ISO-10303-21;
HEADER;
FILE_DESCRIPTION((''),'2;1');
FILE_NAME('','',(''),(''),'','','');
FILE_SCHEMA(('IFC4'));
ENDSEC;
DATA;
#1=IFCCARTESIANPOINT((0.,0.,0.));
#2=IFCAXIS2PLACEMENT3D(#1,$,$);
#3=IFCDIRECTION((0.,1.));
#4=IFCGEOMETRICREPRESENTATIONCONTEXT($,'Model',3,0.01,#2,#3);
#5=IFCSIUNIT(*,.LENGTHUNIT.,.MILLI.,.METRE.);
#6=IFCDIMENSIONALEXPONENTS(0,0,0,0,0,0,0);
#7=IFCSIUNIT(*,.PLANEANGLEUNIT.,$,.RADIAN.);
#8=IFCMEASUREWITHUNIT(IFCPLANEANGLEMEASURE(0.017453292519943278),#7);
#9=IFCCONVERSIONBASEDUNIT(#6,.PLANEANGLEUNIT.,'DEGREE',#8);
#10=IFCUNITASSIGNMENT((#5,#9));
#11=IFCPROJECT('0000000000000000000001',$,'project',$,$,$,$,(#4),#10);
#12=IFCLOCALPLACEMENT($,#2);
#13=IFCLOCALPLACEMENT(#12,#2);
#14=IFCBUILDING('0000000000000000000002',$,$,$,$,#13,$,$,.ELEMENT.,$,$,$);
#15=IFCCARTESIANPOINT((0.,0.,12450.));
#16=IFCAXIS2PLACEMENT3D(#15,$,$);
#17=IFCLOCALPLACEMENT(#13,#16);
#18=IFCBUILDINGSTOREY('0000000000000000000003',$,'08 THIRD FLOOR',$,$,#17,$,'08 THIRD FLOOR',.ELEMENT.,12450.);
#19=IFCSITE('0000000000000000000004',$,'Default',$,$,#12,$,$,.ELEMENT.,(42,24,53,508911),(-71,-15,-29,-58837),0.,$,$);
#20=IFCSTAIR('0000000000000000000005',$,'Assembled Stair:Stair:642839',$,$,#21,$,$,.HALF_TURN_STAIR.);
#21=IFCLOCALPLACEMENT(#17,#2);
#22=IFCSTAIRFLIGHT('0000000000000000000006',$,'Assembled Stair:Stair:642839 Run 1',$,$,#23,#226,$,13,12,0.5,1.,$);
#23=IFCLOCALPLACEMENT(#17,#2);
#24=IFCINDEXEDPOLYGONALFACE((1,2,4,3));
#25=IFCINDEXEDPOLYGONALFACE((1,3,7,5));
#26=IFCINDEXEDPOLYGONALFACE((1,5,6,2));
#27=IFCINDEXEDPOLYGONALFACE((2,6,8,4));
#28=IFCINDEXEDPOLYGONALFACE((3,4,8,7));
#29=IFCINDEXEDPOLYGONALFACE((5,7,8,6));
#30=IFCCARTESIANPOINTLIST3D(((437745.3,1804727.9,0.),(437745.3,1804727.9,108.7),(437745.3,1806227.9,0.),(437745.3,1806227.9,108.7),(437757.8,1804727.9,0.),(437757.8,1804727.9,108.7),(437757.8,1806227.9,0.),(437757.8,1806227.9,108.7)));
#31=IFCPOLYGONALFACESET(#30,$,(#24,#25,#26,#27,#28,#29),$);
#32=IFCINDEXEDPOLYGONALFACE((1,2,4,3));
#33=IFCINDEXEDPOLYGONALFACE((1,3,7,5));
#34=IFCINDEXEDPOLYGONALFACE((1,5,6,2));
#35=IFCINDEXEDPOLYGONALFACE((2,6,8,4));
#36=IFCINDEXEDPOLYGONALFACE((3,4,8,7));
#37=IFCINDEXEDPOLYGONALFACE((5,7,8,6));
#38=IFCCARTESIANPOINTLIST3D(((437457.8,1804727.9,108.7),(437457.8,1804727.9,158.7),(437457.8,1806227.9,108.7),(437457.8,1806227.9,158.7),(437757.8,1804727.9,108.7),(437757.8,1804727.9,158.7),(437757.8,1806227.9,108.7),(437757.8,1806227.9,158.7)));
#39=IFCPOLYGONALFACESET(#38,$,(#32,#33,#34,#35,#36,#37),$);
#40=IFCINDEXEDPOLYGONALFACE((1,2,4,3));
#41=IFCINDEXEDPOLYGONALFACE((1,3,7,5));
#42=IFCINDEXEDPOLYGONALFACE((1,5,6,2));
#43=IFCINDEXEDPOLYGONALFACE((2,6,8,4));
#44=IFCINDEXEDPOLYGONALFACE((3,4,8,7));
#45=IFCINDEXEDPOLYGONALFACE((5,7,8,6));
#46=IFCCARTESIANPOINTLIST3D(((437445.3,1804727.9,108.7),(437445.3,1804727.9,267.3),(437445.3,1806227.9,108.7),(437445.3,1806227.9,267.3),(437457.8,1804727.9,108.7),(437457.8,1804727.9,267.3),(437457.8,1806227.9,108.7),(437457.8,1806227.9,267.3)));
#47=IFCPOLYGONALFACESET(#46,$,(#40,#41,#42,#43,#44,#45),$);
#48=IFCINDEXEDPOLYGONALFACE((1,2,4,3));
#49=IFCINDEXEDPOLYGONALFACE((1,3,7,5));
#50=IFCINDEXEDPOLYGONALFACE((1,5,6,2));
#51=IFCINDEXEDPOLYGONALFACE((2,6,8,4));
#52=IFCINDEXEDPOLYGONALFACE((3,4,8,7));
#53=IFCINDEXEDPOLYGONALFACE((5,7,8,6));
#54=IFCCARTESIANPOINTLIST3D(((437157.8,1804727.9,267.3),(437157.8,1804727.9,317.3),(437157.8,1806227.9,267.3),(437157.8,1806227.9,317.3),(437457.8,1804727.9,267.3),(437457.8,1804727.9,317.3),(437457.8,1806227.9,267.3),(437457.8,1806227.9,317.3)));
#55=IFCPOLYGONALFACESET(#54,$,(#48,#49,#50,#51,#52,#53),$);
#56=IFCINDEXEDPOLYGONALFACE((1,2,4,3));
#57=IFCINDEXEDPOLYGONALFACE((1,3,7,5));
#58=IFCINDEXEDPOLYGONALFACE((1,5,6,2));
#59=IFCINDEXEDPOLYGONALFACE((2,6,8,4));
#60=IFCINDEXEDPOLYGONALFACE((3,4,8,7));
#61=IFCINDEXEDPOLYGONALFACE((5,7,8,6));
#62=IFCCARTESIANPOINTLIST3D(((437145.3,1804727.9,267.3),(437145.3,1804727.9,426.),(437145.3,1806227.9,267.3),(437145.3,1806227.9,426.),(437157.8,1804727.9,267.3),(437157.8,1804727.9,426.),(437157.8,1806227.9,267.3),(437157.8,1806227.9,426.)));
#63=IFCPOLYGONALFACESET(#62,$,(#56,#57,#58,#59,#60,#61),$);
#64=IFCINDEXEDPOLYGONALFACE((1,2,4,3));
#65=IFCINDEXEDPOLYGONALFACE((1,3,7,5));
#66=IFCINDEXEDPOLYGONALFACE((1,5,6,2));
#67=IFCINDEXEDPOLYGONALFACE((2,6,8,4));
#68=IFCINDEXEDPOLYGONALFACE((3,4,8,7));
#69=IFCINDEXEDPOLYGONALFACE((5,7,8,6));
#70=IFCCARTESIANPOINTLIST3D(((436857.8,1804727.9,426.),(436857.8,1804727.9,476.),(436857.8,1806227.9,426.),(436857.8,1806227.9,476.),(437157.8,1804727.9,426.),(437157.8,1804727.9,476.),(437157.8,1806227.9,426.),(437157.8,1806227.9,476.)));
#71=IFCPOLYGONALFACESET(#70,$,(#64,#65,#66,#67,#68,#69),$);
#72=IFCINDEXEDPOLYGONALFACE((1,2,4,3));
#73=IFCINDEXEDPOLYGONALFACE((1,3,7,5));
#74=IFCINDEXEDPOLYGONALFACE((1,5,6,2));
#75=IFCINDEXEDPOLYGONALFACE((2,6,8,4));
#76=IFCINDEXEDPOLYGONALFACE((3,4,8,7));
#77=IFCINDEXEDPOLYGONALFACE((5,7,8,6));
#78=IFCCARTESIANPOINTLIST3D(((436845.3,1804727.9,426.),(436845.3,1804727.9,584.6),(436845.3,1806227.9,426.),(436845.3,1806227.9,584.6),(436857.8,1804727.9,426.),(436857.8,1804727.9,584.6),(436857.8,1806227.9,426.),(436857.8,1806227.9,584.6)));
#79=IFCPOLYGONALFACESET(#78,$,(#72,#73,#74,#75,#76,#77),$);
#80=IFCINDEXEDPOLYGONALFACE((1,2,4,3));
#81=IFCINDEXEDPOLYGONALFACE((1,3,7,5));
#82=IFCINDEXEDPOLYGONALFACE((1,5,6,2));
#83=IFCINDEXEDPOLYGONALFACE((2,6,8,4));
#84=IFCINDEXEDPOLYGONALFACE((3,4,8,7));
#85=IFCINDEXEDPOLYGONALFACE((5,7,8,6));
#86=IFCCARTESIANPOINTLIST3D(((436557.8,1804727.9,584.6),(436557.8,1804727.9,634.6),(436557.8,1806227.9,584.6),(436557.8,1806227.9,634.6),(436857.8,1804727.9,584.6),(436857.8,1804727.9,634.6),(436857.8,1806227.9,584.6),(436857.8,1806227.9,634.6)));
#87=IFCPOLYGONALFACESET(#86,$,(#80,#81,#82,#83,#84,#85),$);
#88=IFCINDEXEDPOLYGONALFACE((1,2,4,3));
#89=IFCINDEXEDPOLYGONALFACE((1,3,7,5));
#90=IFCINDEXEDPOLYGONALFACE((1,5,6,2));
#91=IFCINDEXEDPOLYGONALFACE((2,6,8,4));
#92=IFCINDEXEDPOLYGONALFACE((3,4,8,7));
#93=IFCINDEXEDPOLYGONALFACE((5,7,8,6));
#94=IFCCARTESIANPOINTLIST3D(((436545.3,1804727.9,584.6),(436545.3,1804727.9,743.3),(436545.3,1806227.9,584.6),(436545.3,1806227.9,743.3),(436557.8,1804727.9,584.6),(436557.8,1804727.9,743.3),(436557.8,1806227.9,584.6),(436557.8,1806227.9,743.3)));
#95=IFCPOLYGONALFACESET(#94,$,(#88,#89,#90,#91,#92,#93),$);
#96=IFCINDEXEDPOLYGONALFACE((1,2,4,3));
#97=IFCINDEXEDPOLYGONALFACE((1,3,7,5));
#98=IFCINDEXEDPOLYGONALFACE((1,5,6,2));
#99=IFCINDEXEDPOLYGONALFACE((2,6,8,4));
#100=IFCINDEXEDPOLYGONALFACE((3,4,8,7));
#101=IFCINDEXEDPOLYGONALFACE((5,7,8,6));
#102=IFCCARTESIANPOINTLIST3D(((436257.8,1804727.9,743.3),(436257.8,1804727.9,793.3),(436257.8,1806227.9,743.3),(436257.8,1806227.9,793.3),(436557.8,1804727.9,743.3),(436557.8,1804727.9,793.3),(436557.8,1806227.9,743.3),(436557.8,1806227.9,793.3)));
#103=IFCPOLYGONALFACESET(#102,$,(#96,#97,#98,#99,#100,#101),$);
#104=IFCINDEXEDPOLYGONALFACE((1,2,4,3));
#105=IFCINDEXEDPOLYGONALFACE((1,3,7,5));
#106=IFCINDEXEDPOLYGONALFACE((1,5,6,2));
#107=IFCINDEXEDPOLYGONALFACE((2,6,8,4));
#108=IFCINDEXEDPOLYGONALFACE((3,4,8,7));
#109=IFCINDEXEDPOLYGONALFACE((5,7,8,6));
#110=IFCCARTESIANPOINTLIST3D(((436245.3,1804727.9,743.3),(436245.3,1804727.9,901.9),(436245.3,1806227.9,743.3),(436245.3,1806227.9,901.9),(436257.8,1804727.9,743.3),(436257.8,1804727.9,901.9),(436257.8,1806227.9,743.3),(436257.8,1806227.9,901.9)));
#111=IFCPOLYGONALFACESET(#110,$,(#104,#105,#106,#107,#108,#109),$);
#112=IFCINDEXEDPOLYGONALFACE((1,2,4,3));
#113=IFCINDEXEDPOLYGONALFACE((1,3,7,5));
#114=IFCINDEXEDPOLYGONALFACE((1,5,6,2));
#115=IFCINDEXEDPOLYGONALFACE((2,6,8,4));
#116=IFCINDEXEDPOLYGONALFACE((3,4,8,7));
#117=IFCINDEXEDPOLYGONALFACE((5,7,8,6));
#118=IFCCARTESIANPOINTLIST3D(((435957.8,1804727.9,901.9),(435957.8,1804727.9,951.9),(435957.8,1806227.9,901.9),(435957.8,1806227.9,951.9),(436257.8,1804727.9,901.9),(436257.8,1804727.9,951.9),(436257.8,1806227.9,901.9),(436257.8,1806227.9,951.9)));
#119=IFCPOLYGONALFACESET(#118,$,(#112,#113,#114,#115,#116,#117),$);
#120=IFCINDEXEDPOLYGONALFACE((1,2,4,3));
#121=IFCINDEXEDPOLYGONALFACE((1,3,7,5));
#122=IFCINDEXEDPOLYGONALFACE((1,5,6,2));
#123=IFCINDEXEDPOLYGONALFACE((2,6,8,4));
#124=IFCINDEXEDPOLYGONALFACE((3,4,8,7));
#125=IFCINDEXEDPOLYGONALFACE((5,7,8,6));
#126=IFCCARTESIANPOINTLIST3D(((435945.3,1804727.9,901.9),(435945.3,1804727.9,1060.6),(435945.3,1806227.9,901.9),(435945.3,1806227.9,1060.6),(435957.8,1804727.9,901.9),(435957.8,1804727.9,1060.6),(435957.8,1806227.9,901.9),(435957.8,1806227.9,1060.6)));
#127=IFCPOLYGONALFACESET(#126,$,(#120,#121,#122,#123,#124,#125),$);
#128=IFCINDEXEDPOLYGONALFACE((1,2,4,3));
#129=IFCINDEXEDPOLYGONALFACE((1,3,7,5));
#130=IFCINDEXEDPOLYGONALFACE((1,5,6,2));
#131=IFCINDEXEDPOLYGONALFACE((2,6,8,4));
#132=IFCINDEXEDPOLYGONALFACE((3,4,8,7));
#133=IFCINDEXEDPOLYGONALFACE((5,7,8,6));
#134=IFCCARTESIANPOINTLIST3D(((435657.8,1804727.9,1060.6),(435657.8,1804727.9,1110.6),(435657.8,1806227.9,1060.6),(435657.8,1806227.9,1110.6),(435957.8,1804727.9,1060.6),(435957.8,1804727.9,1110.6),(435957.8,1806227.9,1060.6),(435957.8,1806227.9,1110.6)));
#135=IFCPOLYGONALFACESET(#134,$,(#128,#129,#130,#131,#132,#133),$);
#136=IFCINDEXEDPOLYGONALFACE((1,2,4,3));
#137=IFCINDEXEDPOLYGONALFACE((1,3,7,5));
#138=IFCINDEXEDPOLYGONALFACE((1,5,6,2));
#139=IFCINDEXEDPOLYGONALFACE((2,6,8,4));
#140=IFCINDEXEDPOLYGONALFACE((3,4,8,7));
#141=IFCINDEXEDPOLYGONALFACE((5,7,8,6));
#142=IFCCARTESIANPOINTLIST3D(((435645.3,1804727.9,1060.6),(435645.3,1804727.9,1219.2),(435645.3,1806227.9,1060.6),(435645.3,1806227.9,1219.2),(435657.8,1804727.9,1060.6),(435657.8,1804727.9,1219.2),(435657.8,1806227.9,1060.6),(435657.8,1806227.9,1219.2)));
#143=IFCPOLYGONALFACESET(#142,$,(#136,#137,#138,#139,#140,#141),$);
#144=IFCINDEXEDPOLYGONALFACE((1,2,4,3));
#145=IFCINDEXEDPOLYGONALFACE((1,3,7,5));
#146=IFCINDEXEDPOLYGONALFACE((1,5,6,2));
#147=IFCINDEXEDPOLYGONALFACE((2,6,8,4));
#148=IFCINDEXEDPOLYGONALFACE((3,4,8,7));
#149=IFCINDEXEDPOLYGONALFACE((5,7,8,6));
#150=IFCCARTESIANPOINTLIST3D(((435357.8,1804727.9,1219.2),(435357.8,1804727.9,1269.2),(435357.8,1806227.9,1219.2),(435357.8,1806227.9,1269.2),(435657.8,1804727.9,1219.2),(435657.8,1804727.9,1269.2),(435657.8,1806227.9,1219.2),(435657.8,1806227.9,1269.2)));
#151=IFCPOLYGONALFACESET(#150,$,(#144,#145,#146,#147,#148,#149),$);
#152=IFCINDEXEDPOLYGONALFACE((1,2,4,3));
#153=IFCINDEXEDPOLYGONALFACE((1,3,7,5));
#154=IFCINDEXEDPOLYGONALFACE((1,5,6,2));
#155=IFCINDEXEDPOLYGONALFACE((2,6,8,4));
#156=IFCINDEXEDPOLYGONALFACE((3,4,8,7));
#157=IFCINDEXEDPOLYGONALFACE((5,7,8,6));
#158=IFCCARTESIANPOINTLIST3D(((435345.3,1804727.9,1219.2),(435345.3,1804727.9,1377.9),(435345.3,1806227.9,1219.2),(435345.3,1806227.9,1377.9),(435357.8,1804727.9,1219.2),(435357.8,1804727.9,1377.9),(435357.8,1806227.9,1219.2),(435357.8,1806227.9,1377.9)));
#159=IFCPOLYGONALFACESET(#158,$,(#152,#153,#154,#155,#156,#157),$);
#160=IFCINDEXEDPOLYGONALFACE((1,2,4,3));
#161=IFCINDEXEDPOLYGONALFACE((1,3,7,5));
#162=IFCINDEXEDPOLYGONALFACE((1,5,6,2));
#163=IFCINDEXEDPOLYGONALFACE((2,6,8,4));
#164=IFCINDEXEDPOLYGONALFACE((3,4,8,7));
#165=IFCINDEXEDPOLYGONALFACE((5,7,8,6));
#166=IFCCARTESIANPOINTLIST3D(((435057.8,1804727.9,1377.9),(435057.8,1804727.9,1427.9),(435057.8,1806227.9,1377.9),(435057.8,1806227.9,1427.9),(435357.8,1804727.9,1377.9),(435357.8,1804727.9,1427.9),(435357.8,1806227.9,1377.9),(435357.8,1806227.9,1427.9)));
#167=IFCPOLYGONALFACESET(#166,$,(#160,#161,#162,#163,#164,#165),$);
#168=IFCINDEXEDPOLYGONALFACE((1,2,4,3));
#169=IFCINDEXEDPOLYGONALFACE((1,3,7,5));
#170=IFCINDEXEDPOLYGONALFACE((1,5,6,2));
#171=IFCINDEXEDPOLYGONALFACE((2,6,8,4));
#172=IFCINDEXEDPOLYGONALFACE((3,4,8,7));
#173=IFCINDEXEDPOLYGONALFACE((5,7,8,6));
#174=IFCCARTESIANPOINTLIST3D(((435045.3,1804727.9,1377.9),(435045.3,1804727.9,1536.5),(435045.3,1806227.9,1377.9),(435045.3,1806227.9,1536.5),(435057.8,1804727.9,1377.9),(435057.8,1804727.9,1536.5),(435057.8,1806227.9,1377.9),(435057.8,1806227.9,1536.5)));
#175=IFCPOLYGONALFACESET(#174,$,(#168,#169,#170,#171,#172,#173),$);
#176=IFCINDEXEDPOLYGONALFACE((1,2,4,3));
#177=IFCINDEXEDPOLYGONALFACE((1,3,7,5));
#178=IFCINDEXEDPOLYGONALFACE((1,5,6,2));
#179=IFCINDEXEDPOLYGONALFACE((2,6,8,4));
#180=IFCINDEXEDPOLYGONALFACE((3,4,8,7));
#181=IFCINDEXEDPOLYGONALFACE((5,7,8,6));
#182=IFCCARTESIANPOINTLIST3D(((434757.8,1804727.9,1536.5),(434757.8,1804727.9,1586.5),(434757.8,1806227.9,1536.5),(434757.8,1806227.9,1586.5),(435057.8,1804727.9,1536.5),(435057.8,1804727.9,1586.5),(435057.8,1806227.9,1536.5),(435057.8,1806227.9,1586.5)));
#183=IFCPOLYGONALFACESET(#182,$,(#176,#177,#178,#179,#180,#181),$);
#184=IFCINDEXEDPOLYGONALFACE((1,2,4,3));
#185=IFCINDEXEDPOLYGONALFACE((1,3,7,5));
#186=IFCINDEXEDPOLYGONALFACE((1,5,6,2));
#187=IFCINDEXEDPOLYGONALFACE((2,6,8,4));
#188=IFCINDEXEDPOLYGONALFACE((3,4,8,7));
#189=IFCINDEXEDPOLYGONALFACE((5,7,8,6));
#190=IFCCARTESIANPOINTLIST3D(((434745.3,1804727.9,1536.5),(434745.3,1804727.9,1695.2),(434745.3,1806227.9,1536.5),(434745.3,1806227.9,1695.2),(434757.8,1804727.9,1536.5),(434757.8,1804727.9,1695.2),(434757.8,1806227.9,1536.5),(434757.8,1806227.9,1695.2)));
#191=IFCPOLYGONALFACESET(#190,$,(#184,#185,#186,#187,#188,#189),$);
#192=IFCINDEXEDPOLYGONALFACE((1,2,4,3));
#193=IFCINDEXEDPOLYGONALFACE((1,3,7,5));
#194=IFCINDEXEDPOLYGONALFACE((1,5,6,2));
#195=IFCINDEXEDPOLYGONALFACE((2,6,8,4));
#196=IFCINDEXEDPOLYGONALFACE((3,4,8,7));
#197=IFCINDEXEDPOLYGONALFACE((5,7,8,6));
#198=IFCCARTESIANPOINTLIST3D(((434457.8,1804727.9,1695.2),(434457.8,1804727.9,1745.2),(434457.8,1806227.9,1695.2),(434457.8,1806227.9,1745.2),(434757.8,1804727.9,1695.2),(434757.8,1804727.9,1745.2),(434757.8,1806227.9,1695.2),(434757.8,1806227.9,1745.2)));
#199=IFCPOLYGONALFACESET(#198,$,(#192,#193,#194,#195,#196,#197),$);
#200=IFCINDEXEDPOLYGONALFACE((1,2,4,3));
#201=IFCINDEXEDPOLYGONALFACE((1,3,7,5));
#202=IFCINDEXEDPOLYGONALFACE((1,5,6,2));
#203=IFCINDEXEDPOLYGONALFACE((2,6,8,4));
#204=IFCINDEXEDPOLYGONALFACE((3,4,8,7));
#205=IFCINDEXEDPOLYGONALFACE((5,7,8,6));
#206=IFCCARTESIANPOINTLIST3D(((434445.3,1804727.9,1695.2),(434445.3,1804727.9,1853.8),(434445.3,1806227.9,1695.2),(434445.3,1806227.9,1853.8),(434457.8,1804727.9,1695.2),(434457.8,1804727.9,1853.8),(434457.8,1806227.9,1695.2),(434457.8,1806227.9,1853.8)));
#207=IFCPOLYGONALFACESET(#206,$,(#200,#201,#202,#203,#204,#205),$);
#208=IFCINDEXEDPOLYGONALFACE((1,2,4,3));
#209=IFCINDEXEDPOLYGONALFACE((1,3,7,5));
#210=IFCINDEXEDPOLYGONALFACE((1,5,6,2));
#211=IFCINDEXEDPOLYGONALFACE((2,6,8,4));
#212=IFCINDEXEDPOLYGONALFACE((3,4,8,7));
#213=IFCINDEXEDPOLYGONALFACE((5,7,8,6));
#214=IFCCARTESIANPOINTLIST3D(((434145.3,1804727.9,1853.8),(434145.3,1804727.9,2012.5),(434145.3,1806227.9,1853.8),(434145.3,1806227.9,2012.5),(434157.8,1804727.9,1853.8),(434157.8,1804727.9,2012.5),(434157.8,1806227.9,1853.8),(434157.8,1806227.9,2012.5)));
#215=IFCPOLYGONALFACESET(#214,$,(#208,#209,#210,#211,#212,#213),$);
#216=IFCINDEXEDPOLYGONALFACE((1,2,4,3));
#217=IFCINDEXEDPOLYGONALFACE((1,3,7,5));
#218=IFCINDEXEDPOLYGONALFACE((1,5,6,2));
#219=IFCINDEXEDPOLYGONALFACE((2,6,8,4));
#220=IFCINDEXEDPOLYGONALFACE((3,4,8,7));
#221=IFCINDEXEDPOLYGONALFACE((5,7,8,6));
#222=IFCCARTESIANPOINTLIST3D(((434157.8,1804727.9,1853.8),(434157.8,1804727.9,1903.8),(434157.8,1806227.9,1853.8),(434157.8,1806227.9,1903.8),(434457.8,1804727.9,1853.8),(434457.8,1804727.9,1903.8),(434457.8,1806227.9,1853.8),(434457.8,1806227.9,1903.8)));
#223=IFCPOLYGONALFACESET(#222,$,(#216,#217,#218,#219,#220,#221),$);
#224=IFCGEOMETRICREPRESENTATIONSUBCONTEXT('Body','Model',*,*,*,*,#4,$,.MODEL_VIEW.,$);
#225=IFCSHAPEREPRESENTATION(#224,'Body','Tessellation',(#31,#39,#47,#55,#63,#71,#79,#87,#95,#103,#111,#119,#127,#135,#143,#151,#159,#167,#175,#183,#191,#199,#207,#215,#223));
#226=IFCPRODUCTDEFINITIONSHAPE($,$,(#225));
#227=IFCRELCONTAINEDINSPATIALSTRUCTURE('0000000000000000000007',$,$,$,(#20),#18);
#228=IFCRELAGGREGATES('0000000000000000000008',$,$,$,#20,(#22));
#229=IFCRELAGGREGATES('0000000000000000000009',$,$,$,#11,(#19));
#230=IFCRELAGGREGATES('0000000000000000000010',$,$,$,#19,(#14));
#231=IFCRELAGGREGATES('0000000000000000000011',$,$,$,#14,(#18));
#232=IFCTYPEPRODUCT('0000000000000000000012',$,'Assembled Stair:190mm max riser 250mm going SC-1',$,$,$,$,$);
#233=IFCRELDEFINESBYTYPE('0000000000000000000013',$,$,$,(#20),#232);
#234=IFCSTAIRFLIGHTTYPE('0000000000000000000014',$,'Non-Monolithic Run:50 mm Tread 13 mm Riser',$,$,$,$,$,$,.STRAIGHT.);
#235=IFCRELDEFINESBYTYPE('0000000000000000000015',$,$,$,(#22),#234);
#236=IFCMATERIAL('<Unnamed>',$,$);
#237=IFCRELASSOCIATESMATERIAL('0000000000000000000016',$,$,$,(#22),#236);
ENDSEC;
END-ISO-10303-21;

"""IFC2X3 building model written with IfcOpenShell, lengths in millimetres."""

from ifc_helpers import new_model, entity, si_unit, converted_unit, direction, frame, origin, origin_2d_with_axis, place, context, subcontext, project, spatial, rectangle, extrude, material, type_object, element, aggregate, save


model = new_model("IFC2X3")

# Units and contexts
model_context = context("Model", 3, precision=0.01, world=origin(), true_north=direction((0.0, 1.0)))
body_context = subcontext(model_context, "Body", "Model", "MODEL_VIEW")
ifc_project = project(units=[si_unit("LENGTHUNIT", "METRE", prefix="MILLI"), converted_unit("PLANEANGLEUNIT", "DEGREE", entity("IfcPlaneAngleMeasure", 0.017453292519943278), si_unit("PLANEANGLEUNIT", "RADIAN"), dimensions=[0, 0, 0, 0, 0, 0, 0])], contexts=[model_context])

# Site, building, storey
site_placement = place(None, origin())
site = spatial("IfcSite", under=ifc_project, at=site_placement, Name="Default", CompositionType="ELEMENT", RefLatitude=(42, 24, 53, 508911), RefLongitude=(-71, -15, -29, -58837), RefElevation=0.0)
building_placement = place(site_placement, origin())
building = spatial("IfcBuilding", under=site, at=building_placement, CompositionType="ELEMENT")
storey_placement = place(building_placement, frame((0.0, 0.0, 12450.0)))
storey = spatial("IfcBuildingStorey", under=building, at=storey_placement, Name="08 THIRD FLOOR", LongName="08 THIRD FLOOR", CompositionType="ELEMENT", Elevation=12450.0)

# Stair
type_product_1 = type_object("IfcTypeProduct", Name="Assembled Stair:190mm max riser 250mm going SC-1")
stair_1_placement = place(storey_placement, origin())
stair_1 = element("IfcStair", 1, at=stair_1_placement, inside=storey, type_object=type_product_1, Name="Assembled Stair:Stair:642839", ShapeType="HALF_TURN_STAIR")
ifc_material_1 = material(Name="<Unnamed>")

# Stair flight
stair_flight_type = type_object("IfcStairFlightType", Name="Non-Monolithic Run:50 mm Tread 13 mm Riser", PredefinedType="STRAIGHT")
stair_flight_1_placement = place(stair_1_placement, origin())
stair_flight_1 = element("IfcStairFlight", 2, at=stair_flight_1_placement, type_object=stair_flight_type, material=ifc_material_1, Name="Assembled Stair:Stair:642839 Run 1", NumberOfRiser=13, NumberOfTreads=12, RiserHeight=0.5, TreadLength=1.0, context=body_context, shape_type="SweptSolid", body=[
    extrude(rectangle(XDim=1500.0, YDim=12.5, at=origin_2d_with_axis()), frame((437751.5, 1805477.9, 0.0), z_axis=(0.0, 0.0, 1.0), x_axis=(0.0, -1.0, 0.0)), (0.0, 0.0, 1.0), 108.7),
    extrude(rectangle(XDim=300.0, YDim=1500.0, at=origin_2d_with_axis()), frame((437607.8, 1805477.9, 108.7)), (0.0, 0.0, 1.0), 50.0),
    extrude(rectangle(XDim=1500.0, YDim=12.5, at=origin_2d_with_axis()), frame((437451.5, 1805477.9, 108.7), z_axis=(0.0, 0.0, 1.0), x_axis=(0.0, -1.0, 0.0)), (0.0, 0.0, 1.0), 158.7),
    extrude(rectangle(XDim=300.0, YDim=1500.0, at=origin_2d_with_axis()), frame((437307.8, 1805477.9, 267.3)), (0.0, 0.0, 1.0), 50.0),
    extrude(rectangle(XDim=1500.0, YDim=12.5, at=origin_2d_with_axis()), frame((437151.5, 1805477.9, 267.3), z_axis=(0.0, 0.0, 1.0), x_axis=(0.0, -1.0, 0.0)), (0.0, 0.0, 1.0), 158.7),
    extrude(rectangle(XDim=300.0, YDim=1500.0, at=origin_2d_with_axis()), frame((437007.8, 1805477.9, 426.0)), (0.0, 0.0, 1.0), 50.0),
    extrude(rectangle(XDim=1500.0, YDim=12.5, at=origin_2d_with_axis()), frame((436851.5, 1805477.9, 426.0), z_axis=(0.0, 0.0, 1.0), x_axis=(0.0, -1.0, 0.0)), (0.0, 0.0, 1.0), 158.7),
    extrude(rectangle(XDim=300.0, YDim=1500.0, at=origin_2d_with_axis()), frame((436707.8, 1805477.9, 584.6)), (0.0, 0.0, 1.0), 50.0),
    extrude(rectangle(XDim=1500.0, YDim=12.5, at=origin_2d_with_axis()), frame((436551.5, 1805477.9, 584.6), z_axis=(0.0, 0.0, 1.0), x_axis=(0.0, -1.0, 0.0)), (0.0, 0.0, 1.0), 158.7),
    extrude(rectangle(XDim=300.0, YDim=1500.0, at=origin_2d_with_axis()), frame((436407.8, 1805477.9, 743.3)), (0.0, 0.0, 1.0), 50.0),
    extrude(rectangle(XDim=1500.0, YDim=12.5, at=origin_2d_with_axis()), frame((436251.5, 1805477.9, 743.3), z_axis=(0.0, 0.0, 1.0), x_axis=(0.0, -1.0, 0.0)), (0.0, 0.0, 1.0), 158.7),
    extrude(rectangle(XDim=300.0, YDim=1500.0, at=origin_2d_with_axis()), frame((436107.8, 1805477.9, 901.9)), (0.0, 0.0, 1.0), 50.0),
    extrude(rectangle(XDim=1500.0, YDim=12.5, at=origin_2d_with_axis()), frame((435951.5, 1805477.9, 901.9), z_axis=(0.0, 0.0, 1.0), x_axis=(0.0, -1.0, 0.0)), (0.0, 0.0, 1.0), 158.7),
    extrude(rectangle(XDim=300.0, YDim=1500.0, at=origin_2d_with_axis()), frame((435807.8, 1805477.9, 1060.6)), (0.0, 0.0, 1.0), 50.0),
    extrude(rectangle(XDim=1500.0, YDim=12.5, at=origin_2d_with_axis()), frame((435651.5, 1805477.9, 1060.6), z_axis=(0.0, 0.0, 1.0), x_axis=(0.0, -1.0, 0.0)), (0.0, 0.0, 1.0), 158.7),
    extrude(rectangle(XDim=300.0, YDim=1500.0, at=origin_2d_with_axis()), frame((435507.8, 1805477.9, 1219.2)), (0.0, 0.0, 1.0), 50.0),
    extrude(rectangle(XDim=1500.0, YDim=12.5, at=origin_2d_with_axis()), frame((435351.5, 1805477.9, 1219.2), z_axis=(0.0, 0.0, 1.0), x_axis=(0.0, -1.0, 0.0)), (0.0, 0.0, 1.0), 158.7),
    extrude(rectangle(XDim=300.0, YDim=1500.0, at=origin_2d_with_axis()), frame((435207.8, 1805477.9, 1377.9)), (0.0, 0.0, 1.0), 50.0),
    extrude(rectangle(XDim=1500.0, YDim=12.5, at=origin_2d_with_axis()), frame((435051.5, 1805477.9, 1377.9), z_axis=(0.0, 0.0, 1.0), x_axis=(0.0, -1.0, 0.0)), (0.0, 0.0, 1.0), 158.7),
    extrude(rectangle(XDim=300.0, YDim=1500.0, at=origin_2d_with_axis()), frame((434907.8, 1805477.9, 1536.5)), (0.0, 0.0, 1.0), 50.0),
    extrude(rectangle(XDim=1500.0, YDim=12.5, at=origin_2d_with_axis()), frame((434751.5, 1805477.9, 1536.5), z_axis=(0.0, 0.0, 1.0), x_axis=(0.0, -1.0, 0.0)), (0.0, 0.0, 1.0), 158.7),
    extrude(rectangle(XDim=300.0, YDim=1500.0, at=origin_2d_with_axis()), frame((434607.8, 1805477.9, 1695.2)), (0.0, 0.0, 1.0), 50.0),
    extrude(rectangle(XDim=1500.0, YDim=12.5, at=origin_2d_with_axis()), frame((434451.5, 1805477.9, 1695.2), z_axis=(0.0, 0.0, 1.0), x_axis=(0.0, -1.0, 0.0)), (0.0, 0.0, 1.0), 158.7),
    extrude(rectangle(XDim=1500.0, YDim=12.5, at=origin_2d_with_axis()), frame((434151.5, 1805477.9, 1853.8), z_axis=(0.0, 0.0, 1.0), x_axis=(0.0, -1.0, 0.0)), (0.0, 0.0, 1.0), 158.7),
    extrude(rectangle(XDim=300.0, YDim=1500.0, at=origin_2d_with_axis()), frame((434307.8, 1805477.9, 1853.8)), (0.0, 0.0, 1.0), 50.0),
])
aggregate(stair_1, [stair_flight_1])

save(model, "model.ifc")
